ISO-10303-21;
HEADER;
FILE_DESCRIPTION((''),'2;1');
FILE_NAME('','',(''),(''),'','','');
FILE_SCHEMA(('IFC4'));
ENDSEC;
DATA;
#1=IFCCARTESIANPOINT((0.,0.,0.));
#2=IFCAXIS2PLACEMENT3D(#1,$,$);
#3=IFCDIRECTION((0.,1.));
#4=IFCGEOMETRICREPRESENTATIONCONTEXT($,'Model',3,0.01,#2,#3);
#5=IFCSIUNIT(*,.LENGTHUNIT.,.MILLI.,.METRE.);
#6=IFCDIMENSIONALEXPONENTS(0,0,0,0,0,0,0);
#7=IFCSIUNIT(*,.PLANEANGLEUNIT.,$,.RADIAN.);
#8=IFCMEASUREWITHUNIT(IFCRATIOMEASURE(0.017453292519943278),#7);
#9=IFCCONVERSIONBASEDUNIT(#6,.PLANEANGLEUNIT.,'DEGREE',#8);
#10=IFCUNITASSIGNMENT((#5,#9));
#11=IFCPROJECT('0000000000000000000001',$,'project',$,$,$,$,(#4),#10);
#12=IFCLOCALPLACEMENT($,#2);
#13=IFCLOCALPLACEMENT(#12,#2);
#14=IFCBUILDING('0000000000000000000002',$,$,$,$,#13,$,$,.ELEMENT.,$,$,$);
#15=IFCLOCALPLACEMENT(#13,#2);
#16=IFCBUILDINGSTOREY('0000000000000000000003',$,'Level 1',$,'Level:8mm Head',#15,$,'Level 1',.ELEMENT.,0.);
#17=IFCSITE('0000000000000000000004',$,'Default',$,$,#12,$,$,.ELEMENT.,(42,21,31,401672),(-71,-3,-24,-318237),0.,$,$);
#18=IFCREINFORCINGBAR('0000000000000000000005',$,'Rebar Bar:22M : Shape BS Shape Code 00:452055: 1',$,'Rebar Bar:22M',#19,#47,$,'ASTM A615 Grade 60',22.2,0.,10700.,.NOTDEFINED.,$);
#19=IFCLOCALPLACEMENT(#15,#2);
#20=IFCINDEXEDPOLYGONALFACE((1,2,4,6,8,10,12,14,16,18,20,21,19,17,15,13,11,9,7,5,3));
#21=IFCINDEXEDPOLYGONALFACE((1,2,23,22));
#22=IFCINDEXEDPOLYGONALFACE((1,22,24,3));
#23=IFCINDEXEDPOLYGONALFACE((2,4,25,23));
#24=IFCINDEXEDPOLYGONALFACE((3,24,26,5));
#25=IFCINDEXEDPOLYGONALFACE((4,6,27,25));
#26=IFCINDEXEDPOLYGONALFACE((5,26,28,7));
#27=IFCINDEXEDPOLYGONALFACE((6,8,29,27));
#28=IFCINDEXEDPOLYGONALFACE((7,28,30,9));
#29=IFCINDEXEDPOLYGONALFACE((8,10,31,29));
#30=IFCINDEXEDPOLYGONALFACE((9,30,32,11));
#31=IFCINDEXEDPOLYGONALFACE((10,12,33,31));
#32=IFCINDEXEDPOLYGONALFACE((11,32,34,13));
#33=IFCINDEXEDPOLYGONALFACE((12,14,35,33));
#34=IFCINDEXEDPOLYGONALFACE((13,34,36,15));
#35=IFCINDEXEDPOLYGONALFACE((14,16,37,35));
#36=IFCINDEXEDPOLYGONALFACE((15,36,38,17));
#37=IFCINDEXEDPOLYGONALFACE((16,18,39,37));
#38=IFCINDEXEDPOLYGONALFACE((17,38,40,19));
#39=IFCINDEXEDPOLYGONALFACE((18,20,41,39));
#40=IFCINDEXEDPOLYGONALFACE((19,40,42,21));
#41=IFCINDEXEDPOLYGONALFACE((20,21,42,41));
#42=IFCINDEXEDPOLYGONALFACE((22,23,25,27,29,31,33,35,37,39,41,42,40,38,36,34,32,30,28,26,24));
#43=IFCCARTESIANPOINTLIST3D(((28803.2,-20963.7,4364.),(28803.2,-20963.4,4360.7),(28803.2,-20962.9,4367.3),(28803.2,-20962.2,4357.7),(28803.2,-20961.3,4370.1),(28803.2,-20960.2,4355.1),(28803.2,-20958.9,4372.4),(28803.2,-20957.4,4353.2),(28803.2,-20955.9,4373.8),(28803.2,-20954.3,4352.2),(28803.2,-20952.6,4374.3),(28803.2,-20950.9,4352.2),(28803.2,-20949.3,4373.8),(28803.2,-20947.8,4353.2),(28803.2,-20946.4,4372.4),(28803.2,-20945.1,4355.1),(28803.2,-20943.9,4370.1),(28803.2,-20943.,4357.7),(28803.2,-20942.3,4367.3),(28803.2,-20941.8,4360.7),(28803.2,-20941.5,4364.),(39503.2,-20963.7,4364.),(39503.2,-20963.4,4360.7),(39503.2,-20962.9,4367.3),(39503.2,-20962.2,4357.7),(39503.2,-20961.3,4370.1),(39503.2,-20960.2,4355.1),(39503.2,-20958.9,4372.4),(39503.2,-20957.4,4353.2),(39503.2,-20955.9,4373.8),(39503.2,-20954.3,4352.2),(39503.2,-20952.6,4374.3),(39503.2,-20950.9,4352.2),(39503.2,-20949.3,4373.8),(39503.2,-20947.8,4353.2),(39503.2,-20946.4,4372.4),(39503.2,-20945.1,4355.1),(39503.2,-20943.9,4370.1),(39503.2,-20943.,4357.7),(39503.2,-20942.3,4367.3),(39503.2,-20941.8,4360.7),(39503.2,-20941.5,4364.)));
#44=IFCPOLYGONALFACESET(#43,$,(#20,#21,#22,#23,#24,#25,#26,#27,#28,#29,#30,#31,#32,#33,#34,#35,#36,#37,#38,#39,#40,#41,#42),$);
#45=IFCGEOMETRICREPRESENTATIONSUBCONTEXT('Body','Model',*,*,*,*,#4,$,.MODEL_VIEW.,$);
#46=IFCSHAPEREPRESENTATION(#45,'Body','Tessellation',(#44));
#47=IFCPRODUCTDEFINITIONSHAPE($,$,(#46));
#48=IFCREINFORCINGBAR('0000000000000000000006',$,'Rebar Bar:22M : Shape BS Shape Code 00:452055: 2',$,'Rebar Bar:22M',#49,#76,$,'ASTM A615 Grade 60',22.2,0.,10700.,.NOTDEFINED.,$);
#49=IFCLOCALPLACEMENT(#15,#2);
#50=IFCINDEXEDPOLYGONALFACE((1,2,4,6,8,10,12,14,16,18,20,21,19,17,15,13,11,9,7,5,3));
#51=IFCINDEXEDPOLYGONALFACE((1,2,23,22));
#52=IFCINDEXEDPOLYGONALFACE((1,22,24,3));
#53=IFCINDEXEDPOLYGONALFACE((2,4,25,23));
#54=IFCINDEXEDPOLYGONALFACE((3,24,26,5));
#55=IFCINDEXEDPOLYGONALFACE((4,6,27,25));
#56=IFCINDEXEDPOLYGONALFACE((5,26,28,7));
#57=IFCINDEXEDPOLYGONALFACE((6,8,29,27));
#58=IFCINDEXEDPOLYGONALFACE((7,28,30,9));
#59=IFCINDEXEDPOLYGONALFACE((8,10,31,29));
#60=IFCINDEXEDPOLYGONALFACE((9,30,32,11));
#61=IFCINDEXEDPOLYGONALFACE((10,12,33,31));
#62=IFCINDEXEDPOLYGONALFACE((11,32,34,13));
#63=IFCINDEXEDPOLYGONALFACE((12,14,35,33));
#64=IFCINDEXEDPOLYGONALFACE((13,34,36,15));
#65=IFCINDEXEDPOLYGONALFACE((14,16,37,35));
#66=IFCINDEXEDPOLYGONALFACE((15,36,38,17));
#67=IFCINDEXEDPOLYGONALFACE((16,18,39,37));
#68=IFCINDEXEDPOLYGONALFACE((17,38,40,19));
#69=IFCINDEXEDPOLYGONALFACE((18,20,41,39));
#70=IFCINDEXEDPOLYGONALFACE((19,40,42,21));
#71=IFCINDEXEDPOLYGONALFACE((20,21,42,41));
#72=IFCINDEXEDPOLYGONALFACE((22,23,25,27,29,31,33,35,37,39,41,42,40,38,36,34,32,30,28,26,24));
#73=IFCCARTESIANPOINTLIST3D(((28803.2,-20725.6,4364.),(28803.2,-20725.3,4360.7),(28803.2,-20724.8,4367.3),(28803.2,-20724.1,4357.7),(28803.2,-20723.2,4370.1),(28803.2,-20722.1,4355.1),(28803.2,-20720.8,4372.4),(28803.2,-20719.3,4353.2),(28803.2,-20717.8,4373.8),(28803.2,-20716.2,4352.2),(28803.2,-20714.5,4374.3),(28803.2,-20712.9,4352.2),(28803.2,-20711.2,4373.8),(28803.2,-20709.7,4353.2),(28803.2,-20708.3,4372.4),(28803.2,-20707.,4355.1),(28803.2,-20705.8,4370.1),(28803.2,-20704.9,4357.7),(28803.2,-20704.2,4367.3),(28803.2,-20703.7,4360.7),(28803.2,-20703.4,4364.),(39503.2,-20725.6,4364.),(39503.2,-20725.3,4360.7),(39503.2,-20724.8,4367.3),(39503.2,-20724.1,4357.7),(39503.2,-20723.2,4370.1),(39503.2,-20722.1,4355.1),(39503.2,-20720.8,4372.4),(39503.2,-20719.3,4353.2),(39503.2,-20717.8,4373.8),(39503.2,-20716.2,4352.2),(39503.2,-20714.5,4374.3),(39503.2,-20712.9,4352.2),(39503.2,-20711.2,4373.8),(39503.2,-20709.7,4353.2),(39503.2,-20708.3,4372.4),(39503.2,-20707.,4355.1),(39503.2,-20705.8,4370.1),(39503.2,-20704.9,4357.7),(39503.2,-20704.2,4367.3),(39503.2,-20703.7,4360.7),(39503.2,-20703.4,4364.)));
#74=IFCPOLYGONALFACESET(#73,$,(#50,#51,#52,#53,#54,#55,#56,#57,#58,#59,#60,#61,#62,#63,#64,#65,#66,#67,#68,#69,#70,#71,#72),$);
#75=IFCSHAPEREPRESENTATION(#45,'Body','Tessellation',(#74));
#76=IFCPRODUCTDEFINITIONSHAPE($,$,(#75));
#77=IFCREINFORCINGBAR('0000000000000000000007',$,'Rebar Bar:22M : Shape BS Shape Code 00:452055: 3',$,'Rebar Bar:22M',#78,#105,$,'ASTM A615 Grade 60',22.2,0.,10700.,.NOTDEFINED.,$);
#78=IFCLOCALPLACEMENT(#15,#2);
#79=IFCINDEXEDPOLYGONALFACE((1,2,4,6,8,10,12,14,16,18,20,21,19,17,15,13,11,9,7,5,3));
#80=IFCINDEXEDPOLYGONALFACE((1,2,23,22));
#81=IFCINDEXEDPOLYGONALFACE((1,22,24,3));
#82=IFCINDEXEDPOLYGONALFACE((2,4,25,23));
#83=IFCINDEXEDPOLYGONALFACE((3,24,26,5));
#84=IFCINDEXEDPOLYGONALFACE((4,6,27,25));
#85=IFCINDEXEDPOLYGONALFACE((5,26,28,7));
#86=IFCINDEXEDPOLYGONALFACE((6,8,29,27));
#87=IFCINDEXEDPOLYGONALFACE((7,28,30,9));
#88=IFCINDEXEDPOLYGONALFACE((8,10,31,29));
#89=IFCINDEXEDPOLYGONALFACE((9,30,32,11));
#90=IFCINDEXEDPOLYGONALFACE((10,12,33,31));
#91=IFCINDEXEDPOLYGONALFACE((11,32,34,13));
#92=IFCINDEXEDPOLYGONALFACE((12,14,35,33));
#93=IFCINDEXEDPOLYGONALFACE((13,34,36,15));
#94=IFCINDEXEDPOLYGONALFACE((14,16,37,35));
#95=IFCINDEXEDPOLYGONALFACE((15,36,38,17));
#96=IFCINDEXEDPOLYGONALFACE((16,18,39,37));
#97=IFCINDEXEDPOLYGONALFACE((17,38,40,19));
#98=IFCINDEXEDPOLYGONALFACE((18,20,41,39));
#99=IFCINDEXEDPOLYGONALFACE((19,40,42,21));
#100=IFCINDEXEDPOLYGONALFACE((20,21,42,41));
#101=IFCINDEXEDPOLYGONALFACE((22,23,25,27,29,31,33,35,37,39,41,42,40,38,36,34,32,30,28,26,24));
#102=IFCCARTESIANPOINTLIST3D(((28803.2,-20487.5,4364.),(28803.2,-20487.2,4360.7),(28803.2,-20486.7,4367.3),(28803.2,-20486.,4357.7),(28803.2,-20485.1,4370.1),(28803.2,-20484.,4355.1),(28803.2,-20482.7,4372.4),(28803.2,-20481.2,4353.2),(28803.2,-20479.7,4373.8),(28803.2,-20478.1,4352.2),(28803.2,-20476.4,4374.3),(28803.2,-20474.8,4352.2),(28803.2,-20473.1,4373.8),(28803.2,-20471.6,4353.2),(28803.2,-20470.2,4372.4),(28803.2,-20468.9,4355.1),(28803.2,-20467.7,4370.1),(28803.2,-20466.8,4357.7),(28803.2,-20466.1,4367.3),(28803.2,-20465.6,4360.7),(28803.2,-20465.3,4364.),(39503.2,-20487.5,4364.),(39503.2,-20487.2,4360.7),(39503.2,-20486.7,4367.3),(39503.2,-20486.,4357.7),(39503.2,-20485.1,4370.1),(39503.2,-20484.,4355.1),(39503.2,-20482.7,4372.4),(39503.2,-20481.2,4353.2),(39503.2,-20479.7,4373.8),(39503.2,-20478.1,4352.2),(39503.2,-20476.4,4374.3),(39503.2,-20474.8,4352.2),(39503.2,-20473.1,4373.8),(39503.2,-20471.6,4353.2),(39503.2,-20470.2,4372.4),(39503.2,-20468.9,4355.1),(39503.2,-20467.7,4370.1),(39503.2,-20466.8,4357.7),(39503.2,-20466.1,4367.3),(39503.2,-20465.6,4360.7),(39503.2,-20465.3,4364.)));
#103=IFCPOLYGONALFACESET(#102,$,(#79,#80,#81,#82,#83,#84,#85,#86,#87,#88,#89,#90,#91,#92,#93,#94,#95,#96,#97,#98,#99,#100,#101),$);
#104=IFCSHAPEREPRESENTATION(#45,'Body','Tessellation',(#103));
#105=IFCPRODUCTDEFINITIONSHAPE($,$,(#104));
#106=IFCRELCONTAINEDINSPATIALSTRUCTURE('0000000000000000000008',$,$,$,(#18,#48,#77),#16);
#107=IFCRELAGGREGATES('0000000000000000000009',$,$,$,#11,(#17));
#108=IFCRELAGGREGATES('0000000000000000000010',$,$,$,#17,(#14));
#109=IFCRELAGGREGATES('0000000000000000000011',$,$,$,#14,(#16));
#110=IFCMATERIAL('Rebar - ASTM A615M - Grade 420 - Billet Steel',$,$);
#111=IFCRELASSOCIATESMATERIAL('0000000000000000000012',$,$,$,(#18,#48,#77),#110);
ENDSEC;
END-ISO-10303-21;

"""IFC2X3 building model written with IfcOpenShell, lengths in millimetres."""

from ifc_helpers import new_model, entity, si_unit, converted_unit, direction, origin, place, context, subcontext, project, spatial, material, element, save


model = new_model("IFC2X3")

# Units and contexts
model_context = context("Model", 3, precision=0.01, world=origin(), true_north=direction((0.0, 1.0)))
body_context = subcontext(model_context, "Body", "Model", "MODEL_VIEW")
ifc_project = project(units=[si_unit("LENGTHUNIT", "METRE", prefix="MILLI"), converted_unit("PLANEANGLEUNIT", "DEGREE", entity("IfcRatioMeasure", 0.017453292519943278), si_unit("PLANEANGLEUNIT", "RADIAN"), dimensions=[0, 0, 0, 0, 0, 0, 0])], contexts=[model_context])

# Site, building, storey
site_placement = place(None, origin())
site = spatial("IfcSite", under=ifc_project, at=site_placement, Name="Default", CompositionType="ELEMENT", RefLatitude=(42, 21, 31, 401672), RefLongitude=(-71, -3, -24, -318237), RefElevation=0.0)
building_placement = place(site_placement, origin())
building = spatial("IfcBuilding", under=site, at=building_placement, CompositionType="ELEMENT")
storey_placement = place(building_placement, origin())
storey = spatial("IfcBuildingStorey", under=building, at=storey_placement, Name="Level 1", ObjectType="Level:8mm Head", LongName="Level 1", CompositionType="ELEMENT", Elevation=0.0)

# Reinforcing bars
ifc_material = material(Name="Rebar - ASTM A615M - Grade 420 - Billet Steel")
reinforcing_bar_1_placement = place(storey_placement, origin())
element("IfcReinforcingBar", 1, at=reinforcing_bar_1_placement, inside=storey, material=ifc_material, Name="Rebar Bar:22M : Shape BS Shape Code 00:452055: 1", SteelGrade="ASTM A615 Grade 60", ObjectType="Rebar Bar:22M", BarLength=10700.0, BarRole="NOTDEFINED", CrossSectionArea=0.0, NominalDiameter=22.2, context=body_context, shape_type="AdvancedSweptSolid", body=[
    entity("IfcSweptDiskSolid", entity("IfcCompositeCurve", [entity("IfcCompositeCurveSegment", "CONTINUOUS", True, entity("IfcPolyline", [entity("IfcCartesianPoint", [28803.2, -20952.6, 4363.2]), entity("IfcCartesianPoint", [39503.2, -20952.6, 4363.2])]))], False), 11.1, None, 0.0, 1.0),
])
reinforcing_bar_2_placement = place(storey_placement, origin())
element("IfcReinforcingBar", 2, at=reinforcing_bar_2_placement, inside=storey, material=ifc_material, Name="Rebar Bar:22M : Shape BS Shape Code 00:452055: 2", SteelGrade="ASTM A615 Grade 60", ObjectType="Rebar Bar:22M", BarLength=10700.0, BarRole="NOTDEFINED", CrossSectionArea=0.0, NominalDiameter=22.2, context=body_context, shape_type="AdvancedSweptSolid", body=[
    entity("IfcSweptDiskSolid", entity("IfcCompositeCurve", [entity("IfcCompositeCurveSegment", "CONTINUOUS", True, entity("IfcPolyline", [entity("IfcCartesianPoint", [28803.2, -20714.5, 4363.2]), entity("IfcCartesianPoint", [39503.2, -20714.5, 4363.2])]))], False), 11.1, None, 0.0, 1.0),
])
reinforcing_bar_3_placement = place(storey_placement, origin())
element("IfcReinforcingBar", 3, at=reinforcing_bar_3_placement, inside=storey, material=ifc_material, Name="Rebar Bar:22M : Shape BS Shape Code 00:452055: 3", SteelGrade="ASTM A615 Grade 60", ObjectType="Rebar Bar:22M", BarLength=10700.0, BarRole="NOTDEFINED", CrossSectionArea=0.0, NominalDiameter=22.2, context=body_context, shape_type="AdvancedSweptSolid", body=[
    entity("IfcSweptDiskSolid", entity("IfcCompositeCurve", [entity("IfcCompositeCurveSegment", "CONTINUOUS", True, entity("IfcPolyline", [entity("IfcCartesianPoint", [28803.2, -20476.4, 4363.2]), entity("IfcCartesianPoint", [39503.2, -20476.4, 4363.2])]))], False), 11.1, None, 0.0, 1.0),
])

save(model, "model.ifc")
